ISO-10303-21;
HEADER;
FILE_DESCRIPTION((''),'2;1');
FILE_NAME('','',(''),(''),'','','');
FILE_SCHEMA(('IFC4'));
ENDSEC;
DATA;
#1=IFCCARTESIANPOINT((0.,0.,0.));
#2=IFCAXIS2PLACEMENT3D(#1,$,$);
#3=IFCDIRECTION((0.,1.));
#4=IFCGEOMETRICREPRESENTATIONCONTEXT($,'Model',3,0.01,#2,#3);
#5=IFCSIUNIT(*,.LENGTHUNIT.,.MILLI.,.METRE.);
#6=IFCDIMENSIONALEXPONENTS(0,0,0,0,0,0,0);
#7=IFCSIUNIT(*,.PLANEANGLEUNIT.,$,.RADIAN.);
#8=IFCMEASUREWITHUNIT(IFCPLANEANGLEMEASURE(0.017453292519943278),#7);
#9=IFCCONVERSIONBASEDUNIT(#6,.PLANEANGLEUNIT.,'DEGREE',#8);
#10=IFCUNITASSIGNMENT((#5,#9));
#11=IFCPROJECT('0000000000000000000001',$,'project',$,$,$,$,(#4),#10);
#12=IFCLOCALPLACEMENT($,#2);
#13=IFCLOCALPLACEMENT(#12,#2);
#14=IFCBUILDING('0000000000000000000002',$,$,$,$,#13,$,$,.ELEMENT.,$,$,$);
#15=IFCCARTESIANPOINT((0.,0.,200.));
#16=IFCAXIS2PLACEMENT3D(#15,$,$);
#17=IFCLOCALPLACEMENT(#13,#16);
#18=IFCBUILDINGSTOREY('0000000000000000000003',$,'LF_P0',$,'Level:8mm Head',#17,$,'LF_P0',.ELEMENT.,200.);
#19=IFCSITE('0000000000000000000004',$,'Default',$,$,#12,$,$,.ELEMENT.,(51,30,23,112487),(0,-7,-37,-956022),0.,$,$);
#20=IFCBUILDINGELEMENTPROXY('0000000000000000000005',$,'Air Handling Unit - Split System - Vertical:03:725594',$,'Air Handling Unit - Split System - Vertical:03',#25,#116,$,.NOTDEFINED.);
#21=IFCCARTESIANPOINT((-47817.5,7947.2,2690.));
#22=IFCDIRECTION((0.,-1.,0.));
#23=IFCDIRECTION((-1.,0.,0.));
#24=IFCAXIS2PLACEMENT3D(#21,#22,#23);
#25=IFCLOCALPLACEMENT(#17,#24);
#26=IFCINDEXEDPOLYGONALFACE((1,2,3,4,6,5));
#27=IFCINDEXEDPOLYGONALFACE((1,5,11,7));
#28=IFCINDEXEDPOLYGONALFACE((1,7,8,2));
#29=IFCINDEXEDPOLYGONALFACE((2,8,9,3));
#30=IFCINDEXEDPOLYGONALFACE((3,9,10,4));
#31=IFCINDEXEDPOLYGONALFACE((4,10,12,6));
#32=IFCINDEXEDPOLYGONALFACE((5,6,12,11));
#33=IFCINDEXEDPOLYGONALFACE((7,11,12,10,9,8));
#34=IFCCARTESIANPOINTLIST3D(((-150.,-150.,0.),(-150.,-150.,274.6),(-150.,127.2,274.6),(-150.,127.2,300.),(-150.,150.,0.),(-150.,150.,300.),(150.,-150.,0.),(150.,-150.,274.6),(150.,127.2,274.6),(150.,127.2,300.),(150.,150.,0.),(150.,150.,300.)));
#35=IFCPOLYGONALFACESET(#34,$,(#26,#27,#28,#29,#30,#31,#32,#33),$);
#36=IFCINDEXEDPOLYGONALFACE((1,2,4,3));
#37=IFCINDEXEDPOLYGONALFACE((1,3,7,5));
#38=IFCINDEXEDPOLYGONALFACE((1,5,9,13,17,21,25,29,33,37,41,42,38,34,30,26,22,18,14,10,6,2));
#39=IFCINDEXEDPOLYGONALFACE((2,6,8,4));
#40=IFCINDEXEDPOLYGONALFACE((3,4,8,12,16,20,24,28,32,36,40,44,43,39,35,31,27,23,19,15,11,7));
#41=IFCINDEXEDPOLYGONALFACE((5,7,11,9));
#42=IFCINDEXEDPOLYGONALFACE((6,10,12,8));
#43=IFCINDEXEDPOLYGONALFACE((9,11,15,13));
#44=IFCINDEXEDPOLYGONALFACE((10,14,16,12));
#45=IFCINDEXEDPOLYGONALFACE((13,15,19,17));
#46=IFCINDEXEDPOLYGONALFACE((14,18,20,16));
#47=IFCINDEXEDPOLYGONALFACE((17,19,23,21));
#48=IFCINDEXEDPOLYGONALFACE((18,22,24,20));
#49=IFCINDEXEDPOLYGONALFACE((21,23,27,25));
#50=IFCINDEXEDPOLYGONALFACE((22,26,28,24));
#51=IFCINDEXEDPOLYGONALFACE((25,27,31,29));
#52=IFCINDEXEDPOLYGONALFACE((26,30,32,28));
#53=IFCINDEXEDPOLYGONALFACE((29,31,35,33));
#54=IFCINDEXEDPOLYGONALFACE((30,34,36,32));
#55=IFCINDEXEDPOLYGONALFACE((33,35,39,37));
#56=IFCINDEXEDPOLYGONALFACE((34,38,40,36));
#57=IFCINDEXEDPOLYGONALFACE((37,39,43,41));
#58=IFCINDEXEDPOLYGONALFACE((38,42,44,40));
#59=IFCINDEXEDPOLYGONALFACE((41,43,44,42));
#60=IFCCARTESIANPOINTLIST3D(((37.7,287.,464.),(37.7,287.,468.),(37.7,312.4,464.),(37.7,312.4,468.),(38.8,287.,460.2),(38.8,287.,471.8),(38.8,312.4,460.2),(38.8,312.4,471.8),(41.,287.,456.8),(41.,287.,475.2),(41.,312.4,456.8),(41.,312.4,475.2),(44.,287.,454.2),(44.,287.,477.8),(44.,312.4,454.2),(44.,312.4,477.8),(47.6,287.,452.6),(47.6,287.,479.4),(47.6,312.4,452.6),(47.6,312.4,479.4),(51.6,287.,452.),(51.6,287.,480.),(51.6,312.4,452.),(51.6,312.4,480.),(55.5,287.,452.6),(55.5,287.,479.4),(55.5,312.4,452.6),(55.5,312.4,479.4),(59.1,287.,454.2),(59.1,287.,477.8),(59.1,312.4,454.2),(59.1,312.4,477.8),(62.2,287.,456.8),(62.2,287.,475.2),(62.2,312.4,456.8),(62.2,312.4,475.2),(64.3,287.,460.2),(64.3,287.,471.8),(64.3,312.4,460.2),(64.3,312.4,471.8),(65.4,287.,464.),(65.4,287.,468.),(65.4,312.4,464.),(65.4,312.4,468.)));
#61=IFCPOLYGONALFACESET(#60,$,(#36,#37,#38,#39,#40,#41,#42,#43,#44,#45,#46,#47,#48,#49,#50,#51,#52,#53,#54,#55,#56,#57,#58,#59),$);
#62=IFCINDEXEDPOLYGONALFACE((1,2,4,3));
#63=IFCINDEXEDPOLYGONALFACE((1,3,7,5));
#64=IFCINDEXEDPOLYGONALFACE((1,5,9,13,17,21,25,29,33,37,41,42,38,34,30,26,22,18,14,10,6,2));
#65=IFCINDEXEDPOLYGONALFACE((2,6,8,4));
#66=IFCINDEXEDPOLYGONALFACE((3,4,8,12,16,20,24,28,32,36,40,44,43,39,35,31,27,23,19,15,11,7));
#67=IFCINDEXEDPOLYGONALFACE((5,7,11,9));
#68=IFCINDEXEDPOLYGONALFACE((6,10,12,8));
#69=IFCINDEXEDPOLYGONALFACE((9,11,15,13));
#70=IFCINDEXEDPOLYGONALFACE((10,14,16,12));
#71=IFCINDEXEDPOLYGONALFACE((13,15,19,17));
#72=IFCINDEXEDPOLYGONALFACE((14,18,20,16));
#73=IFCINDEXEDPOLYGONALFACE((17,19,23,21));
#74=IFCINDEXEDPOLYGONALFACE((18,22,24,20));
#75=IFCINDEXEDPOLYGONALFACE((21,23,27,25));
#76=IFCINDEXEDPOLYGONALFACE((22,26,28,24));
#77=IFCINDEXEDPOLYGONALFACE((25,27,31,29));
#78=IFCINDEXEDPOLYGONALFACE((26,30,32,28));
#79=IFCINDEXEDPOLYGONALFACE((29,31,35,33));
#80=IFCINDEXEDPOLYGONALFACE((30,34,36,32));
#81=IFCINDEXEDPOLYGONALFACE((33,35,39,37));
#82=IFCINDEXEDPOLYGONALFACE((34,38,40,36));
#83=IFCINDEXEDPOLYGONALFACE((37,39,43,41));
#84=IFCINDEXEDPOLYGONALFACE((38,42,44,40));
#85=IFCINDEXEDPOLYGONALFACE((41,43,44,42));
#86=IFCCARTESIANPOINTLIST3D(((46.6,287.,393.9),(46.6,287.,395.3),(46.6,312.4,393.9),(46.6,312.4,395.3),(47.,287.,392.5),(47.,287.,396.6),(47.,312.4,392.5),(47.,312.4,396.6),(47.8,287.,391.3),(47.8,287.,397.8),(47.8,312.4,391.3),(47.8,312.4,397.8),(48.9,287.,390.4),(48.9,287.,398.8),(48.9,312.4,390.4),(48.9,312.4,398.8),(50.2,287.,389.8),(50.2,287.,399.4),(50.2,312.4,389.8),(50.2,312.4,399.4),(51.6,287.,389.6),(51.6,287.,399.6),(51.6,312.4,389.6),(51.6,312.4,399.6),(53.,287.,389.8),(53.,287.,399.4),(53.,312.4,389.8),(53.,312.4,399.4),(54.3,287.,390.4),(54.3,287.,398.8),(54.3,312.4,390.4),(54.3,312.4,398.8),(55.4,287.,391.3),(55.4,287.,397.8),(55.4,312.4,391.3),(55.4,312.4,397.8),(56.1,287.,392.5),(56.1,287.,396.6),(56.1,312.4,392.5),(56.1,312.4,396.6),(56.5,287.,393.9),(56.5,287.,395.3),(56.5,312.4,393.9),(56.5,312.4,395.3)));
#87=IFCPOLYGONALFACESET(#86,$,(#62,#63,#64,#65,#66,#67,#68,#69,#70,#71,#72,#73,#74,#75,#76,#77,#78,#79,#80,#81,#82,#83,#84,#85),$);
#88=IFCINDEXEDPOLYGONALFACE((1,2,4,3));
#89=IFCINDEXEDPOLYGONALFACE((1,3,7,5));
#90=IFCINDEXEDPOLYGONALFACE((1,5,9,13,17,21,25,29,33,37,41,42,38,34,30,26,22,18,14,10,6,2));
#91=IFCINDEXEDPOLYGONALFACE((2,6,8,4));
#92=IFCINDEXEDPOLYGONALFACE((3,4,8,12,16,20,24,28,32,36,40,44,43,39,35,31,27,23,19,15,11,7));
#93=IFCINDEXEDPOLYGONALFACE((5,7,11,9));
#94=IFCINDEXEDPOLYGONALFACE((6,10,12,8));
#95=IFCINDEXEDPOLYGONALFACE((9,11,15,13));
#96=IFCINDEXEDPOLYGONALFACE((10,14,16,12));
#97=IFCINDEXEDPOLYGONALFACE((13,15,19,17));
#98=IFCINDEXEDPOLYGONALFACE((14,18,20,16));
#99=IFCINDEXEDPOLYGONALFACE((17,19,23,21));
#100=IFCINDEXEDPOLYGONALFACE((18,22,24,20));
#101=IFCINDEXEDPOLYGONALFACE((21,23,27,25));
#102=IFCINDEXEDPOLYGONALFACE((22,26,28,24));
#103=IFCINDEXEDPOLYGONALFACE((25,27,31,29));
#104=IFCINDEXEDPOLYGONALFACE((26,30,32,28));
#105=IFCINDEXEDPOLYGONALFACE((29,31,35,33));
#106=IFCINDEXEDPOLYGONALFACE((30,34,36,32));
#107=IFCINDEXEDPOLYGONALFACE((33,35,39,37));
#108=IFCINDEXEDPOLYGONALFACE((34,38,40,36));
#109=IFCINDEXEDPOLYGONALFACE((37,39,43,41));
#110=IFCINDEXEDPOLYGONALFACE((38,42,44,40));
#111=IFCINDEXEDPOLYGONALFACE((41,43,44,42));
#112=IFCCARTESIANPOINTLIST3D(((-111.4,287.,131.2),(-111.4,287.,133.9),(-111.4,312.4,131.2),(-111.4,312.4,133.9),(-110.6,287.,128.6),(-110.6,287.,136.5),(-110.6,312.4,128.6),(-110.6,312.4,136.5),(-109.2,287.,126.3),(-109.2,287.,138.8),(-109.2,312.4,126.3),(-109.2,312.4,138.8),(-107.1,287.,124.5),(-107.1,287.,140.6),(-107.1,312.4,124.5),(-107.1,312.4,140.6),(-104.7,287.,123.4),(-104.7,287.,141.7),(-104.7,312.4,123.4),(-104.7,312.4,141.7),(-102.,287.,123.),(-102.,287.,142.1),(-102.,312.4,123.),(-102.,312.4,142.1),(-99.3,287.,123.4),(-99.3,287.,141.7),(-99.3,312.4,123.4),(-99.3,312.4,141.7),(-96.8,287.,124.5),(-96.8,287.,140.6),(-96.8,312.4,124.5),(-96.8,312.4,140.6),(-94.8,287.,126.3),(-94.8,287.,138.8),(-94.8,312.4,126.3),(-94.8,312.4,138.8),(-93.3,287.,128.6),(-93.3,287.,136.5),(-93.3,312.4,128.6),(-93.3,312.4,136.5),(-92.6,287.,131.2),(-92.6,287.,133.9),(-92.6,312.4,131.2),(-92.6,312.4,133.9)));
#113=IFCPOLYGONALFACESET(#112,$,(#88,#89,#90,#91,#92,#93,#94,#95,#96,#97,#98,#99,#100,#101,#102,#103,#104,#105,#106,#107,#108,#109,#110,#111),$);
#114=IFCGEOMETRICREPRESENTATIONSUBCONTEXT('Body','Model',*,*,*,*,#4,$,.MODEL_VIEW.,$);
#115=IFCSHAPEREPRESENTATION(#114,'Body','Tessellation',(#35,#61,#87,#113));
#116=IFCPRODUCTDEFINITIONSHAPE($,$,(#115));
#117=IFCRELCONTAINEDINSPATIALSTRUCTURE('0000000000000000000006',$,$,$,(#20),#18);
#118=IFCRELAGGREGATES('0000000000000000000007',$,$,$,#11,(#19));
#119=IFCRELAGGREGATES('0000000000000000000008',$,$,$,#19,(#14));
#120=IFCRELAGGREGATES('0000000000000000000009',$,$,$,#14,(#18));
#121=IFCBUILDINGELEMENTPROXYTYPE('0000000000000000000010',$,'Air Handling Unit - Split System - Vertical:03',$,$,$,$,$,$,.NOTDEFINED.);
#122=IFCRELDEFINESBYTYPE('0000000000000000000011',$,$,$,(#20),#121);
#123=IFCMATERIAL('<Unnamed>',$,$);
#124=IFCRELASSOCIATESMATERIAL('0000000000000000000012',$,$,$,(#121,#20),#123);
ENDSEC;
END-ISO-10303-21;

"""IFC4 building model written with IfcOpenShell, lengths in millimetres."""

from ifc_helpers import new_model, entity, si_unit, converted_unit, direction, frame, origin, place, context, subcontext, project, spatial, arc, indexed_curve, outline, extrude, source, transform, mapped, material, type_object, type_shapes, element, save


model = new_model("IFC4")

# Units and contexts
model_context = context("Model", 3, precision=0.01, world=origin(), true_north=direction((0.0, 1.0)))
body_context = subcontext(model_context, "Body", "Model", "MODEL_VIEW")
ifc_project = project(units=[si_unit("LENGTHUNIT", "METRE", prefix="MILLI"), converted_unit("PLANEANGLEUNIT", "DEGREE", entity("IfcPlaneAngleMeasure", 0.017453292519943278), si_unit("PLANEANGLEUNIT", "RADIAN"), dimensions=[0, 0, 0, 0, 0, 0, 0])], contexts=[model_context])

# Site, building, storey
site_placement = place(None, origin())
site = spatial("IfcSite", under=ifc_project, at=site_placement, Name="Default", CompositionType="ELEMENT", RefLatitude=(51, 30, 23, 112487), RefLongitude=(0, -7, -37, -956022), RefElevation=0.0)
building_placement = place(site_placement, origin())
building = spatial("IfcBuilding", under=site, at=building_placement, CompositionType="ELEMENT")
storey_placement = place(building_placement, frame((0.0, 0.0, 200.0)))
storey = spatial("IfcBuildingStorey", under=building, at=storey_placement, Name="LF_P0", ObjectType="Level:8mm Head", LongName="LF_P0", CompositionType="ELEMENT", Elevation=200.0)

# Shared definitions
ifc_material = material(Name="<Unnamed>")

# Building element proxy
building_element_proxy_type_1 = type_object("IfcBuildingElementProxyType", Name="Air Handling Unit - Split System - Vertical:03", PredefinedType="NOTDEFINED", material=ifc_material)
shared_shape_1 = source(origin(), body_context, "Body", "SweptSolid", [
    extrude(outline(indexed_curve([(-191.5, -107.6), (108.5, -107.6), (108.5, -84.8), (83.1, -84.8), (83.1, 192.4), (-191.5, 192.4), (-191.5, -107.6)], self_intersect=False)), frame((-150.0, 42.4, 191.5), z_axis=(1.0, 0.0, 0.0), x_axis=(0.0, 0.0, 1.0)), (0.0, 0.0, 1.0), 300.0),
    extrude(outline(indexed_curve([(-14.0, 0.0), (0.0, -14.0), (14.0, 0.0), (0.0, 14.0)], segments=[arc(1, 2, 3), arc(3, 4, 1)], self_intersect=False)), frame((51.6, 287.0, 466.0), z_axis=(0.0, 1.0, 0.0), x_axis=(0.0, 0.0, -1.0)), (0.0, 0.0, 1.0), 25.4),
    extrude(outline(indexed_curve([(-5.0, 0.0), (0.0, -5.0), (5.0, 0.0), (0.0, 5.0)], segments=[arc(1, 2, 3), arc(3, 4, 1)], self_intersect=False)), frame((51.6, 287.0, 394.6), z_axis=(0.0, 1.0, 0.0), x_axis=(0.0, 0.0, -1.0)), (0.0, 0.0, 1.0), 25.4),
    extrude(outline(indexed_curve([(-9.5, 0.0), (0.0, -9.5), (9.5, 0.0), (0.0, 9.5)], segments=[arc(1, 2, 3), arc(3, 4, 1)], self_intersect=False)), frame((-102.0, 287.0, 132.6), z_axis=(0.0, 1.0, 0.0), x_axis=(0.0, 0.0, -1.0)), (0.0, 0.0, 1.0), 25.4),
])
type_shapes(building_element_proxy_type_1, [shared_shape_1])
for number, where, z_axis, x_axis, name in (
    (1, (-47817.5, 7947.2, 2690.0), (0.0, -1.0, 0.0), (-1.0, 0.0, 0.0), "Air Handling Unit - Split System - Vertical:03:725594"),
):
    element("IfcBuildingElementProxy", number, at=place(storey_placement, frame(where, z_axis=z_axis, x_axis=x_axis)), inside=storey, type_object=building_element_proxy_type_1, material=ifc_material, Name=name, ObjectType="Air Handling Unit - Split System - Vertical:03", PredefinedType="NOTDEFINED", context=body_context, shape_type="MappedRepresentation", body=[
        mapped(shared_shape_1, transform((0.0, 0.0, 0.0), scale=1.0)),
    ])

save(model, "model.ifc")
